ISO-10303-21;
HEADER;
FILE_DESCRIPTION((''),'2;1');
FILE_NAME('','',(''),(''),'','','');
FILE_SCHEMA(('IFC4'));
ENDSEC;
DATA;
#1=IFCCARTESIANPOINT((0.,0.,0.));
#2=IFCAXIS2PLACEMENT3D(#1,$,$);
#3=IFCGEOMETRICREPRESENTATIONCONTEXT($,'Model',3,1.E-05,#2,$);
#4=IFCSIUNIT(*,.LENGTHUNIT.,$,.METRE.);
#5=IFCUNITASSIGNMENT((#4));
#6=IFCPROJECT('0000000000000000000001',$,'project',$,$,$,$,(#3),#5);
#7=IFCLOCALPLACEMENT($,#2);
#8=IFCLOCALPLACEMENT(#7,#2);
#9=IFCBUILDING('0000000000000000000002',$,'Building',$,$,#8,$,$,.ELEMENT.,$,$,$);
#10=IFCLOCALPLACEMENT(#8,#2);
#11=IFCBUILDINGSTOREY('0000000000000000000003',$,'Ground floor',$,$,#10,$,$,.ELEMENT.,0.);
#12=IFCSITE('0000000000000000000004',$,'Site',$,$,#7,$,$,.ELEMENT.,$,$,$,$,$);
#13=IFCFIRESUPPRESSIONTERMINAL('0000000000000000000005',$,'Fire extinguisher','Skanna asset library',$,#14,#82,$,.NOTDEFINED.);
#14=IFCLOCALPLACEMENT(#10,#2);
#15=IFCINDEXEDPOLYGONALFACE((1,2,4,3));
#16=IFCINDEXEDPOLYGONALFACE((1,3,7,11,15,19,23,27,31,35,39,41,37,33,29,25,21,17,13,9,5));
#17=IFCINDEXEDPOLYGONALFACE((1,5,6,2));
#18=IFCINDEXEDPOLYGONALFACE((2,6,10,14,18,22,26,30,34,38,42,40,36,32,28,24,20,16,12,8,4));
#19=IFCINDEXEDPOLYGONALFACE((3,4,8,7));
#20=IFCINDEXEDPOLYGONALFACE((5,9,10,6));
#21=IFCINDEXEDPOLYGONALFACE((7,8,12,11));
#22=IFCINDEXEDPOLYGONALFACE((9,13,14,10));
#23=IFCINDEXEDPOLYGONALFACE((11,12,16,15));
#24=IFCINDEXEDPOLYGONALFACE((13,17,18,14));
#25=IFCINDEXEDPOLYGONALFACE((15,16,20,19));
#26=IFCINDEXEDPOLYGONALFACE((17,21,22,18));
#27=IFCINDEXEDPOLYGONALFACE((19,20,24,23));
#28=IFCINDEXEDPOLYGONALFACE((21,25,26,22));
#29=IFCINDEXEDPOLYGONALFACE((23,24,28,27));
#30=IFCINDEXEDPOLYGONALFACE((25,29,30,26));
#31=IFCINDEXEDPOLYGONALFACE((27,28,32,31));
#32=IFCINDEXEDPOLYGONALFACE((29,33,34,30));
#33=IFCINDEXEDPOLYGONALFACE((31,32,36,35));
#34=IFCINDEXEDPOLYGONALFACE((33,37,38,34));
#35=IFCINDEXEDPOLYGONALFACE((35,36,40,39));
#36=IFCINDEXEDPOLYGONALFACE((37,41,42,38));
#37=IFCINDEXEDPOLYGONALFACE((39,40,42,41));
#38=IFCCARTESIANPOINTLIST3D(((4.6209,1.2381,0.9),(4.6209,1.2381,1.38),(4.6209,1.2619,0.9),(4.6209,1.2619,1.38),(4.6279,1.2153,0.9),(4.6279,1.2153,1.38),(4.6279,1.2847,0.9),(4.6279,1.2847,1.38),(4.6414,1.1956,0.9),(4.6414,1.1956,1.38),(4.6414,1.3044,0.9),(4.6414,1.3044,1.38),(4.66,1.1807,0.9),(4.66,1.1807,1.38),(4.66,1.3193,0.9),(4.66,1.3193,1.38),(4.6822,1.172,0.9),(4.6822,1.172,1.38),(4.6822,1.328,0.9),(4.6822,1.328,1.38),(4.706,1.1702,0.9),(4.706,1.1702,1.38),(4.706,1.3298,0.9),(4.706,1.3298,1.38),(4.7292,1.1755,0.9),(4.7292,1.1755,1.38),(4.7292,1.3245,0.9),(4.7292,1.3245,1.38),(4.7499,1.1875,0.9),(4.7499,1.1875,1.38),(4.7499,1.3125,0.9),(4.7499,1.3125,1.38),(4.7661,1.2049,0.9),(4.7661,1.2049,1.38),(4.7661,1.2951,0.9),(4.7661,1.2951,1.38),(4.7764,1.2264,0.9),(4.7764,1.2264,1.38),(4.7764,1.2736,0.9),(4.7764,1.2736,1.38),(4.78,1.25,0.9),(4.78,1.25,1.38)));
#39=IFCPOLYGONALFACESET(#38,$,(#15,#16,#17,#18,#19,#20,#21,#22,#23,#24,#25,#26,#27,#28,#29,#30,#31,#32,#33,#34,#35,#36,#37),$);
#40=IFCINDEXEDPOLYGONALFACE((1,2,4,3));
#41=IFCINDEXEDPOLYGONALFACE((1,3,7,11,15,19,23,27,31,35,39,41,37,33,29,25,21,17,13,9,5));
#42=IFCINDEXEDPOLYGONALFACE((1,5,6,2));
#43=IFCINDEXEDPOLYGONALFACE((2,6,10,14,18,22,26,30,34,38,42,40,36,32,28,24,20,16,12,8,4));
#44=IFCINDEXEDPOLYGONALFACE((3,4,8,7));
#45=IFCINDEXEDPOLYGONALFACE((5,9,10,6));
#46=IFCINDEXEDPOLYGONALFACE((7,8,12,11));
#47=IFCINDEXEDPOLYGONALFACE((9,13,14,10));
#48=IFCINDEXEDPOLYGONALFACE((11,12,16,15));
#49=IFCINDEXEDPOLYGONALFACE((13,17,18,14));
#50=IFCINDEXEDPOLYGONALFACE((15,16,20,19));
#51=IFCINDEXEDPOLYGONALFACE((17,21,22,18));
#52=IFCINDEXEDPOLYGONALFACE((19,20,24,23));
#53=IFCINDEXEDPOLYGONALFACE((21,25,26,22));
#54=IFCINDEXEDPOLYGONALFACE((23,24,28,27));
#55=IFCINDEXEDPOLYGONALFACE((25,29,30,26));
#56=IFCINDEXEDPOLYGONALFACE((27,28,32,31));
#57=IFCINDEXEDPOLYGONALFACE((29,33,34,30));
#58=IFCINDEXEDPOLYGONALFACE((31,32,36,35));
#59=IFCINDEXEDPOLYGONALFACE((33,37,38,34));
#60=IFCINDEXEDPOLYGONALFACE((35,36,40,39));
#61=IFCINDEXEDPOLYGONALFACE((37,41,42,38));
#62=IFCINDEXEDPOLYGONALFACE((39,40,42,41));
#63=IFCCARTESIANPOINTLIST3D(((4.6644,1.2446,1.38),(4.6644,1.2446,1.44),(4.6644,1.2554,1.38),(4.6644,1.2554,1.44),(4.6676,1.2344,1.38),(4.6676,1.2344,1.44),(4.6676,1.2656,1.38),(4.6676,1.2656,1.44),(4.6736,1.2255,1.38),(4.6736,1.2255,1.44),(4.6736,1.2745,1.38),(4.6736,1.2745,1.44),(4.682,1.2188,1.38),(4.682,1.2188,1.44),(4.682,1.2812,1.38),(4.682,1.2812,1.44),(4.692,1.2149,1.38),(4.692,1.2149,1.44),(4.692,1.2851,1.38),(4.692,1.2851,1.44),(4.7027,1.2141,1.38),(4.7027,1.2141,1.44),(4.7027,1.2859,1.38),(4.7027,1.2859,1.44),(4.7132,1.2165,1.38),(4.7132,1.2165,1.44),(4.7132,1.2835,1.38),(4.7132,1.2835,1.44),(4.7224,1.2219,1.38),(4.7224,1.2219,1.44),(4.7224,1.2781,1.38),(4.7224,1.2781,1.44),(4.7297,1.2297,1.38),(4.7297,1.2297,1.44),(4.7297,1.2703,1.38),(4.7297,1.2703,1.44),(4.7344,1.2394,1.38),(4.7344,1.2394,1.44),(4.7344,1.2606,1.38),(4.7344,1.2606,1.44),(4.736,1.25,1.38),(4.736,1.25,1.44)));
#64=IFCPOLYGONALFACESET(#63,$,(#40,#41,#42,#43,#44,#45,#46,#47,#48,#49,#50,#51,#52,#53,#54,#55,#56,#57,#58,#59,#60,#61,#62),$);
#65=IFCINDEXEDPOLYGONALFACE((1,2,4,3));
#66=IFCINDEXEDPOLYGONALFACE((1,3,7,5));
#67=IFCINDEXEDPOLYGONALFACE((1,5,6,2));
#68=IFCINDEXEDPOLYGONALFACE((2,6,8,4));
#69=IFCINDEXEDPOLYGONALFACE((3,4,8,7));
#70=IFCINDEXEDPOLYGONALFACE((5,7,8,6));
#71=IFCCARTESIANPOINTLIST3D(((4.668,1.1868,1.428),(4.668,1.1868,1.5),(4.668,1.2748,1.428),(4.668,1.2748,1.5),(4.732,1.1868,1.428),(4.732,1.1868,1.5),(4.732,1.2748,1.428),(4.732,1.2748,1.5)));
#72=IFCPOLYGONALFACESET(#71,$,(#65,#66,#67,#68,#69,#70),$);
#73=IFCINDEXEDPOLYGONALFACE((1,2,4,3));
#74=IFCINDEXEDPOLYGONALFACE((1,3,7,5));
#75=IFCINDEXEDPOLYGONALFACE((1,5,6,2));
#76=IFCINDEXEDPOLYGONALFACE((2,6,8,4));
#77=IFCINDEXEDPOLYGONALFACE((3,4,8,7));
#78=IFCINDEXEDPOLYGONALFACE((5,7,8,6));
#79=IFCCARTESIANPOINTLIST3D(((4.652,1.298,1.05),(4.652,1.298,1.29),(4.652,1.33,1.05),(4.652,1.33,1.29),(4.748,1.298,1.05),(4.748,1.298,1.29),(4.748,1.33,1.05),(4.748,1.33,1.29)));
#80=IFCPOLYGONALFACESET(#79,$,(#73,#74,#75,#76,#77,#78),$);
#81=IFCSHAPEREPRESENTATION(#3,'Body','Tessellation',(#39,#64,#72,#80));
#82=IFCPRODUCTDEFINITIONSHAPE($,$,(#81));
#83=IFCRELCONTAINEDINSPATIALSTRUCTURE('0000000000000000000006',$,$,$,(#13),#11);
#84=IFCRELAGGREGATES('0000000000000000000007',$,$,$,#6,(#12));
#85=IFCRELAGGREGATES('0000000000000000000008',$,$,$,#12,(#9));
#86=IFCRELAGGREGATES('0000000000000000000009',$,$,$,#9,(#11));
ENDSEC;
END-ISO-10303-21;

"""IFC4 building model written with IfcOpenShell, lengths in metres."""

from ifc_helpers import new_model, si_unit, frame, frame_2d, origin, origin_2d, place, context, project, spatial, rectangle, circle, extrude, element, save


model = new_model("IFC4")

# Units and contexts
model_context = context("Model", 3, precision=1e-05, world=origin())
ifc_project = project(units=[si_unit("LENGTHUNIT", "METRE")], contexts=[model_context])

# Site, building, storey
site_placement = place(None, origin())
site = spatial("IfcSite", under=ifc_project, at=site_placement, Name="Site", CompositionType="ELEMENT")
building_placement = place(site_placement, origin())
building = spatial("IfcBuilding", under=site, at=building_placement, Name="Building", CompositionType="ELEMENT")
storey_placement = place(building_placement, origin())
storey = spatial("IfcBuildingStorey", under=building, at=storey_placement, Name="Ground floor", CompositionType="ELEMENT", Elevation=0.0)

# Fire suppression terminal
fire_suppression_terminal_placement = place(storey_placement, frame((4.7, 1.25, 0.9), z_axis=(0.0, 0.0, 1.0), x_axis=(1.0, 0.0, 0.0)))
element("IfcFireSuppressionTerminal", 1, at=fire_suppression_terminal_placement, inside=storey, Name="Fire extinguisher", Description="Skanna asset library", PredefinedType="NOTDEFINED", context=model_context, shape_type="SweptSolid", body=[
    extrude(circle(Radius=0.08, at=origin_2d()), origin(), (0.0, 0.0, 1.0), 0.48),
    extrude(circle(Radius=0.036, at=origin_2d()), frame((0.0, 0.0, 0.48)), (0.0, 0.0, 1.0), 0.06),
    extrude(rectangle(XDim=0.064, YDim=0.088, at=frame_2d((0.0, -0.0192))), frame((0.0, 0.0, 0.528)), (0.0, 0.0, 1.0), 0.072),
    extrude(rectangle(XDim=0.096, YDim=0.032, at=frame_2d((0.0, 0.064))), frame((0.0, 0.0, 0.15)), (0.0, 0.0, 1.0), 0.24),
])

save(model, "model.ifc")
